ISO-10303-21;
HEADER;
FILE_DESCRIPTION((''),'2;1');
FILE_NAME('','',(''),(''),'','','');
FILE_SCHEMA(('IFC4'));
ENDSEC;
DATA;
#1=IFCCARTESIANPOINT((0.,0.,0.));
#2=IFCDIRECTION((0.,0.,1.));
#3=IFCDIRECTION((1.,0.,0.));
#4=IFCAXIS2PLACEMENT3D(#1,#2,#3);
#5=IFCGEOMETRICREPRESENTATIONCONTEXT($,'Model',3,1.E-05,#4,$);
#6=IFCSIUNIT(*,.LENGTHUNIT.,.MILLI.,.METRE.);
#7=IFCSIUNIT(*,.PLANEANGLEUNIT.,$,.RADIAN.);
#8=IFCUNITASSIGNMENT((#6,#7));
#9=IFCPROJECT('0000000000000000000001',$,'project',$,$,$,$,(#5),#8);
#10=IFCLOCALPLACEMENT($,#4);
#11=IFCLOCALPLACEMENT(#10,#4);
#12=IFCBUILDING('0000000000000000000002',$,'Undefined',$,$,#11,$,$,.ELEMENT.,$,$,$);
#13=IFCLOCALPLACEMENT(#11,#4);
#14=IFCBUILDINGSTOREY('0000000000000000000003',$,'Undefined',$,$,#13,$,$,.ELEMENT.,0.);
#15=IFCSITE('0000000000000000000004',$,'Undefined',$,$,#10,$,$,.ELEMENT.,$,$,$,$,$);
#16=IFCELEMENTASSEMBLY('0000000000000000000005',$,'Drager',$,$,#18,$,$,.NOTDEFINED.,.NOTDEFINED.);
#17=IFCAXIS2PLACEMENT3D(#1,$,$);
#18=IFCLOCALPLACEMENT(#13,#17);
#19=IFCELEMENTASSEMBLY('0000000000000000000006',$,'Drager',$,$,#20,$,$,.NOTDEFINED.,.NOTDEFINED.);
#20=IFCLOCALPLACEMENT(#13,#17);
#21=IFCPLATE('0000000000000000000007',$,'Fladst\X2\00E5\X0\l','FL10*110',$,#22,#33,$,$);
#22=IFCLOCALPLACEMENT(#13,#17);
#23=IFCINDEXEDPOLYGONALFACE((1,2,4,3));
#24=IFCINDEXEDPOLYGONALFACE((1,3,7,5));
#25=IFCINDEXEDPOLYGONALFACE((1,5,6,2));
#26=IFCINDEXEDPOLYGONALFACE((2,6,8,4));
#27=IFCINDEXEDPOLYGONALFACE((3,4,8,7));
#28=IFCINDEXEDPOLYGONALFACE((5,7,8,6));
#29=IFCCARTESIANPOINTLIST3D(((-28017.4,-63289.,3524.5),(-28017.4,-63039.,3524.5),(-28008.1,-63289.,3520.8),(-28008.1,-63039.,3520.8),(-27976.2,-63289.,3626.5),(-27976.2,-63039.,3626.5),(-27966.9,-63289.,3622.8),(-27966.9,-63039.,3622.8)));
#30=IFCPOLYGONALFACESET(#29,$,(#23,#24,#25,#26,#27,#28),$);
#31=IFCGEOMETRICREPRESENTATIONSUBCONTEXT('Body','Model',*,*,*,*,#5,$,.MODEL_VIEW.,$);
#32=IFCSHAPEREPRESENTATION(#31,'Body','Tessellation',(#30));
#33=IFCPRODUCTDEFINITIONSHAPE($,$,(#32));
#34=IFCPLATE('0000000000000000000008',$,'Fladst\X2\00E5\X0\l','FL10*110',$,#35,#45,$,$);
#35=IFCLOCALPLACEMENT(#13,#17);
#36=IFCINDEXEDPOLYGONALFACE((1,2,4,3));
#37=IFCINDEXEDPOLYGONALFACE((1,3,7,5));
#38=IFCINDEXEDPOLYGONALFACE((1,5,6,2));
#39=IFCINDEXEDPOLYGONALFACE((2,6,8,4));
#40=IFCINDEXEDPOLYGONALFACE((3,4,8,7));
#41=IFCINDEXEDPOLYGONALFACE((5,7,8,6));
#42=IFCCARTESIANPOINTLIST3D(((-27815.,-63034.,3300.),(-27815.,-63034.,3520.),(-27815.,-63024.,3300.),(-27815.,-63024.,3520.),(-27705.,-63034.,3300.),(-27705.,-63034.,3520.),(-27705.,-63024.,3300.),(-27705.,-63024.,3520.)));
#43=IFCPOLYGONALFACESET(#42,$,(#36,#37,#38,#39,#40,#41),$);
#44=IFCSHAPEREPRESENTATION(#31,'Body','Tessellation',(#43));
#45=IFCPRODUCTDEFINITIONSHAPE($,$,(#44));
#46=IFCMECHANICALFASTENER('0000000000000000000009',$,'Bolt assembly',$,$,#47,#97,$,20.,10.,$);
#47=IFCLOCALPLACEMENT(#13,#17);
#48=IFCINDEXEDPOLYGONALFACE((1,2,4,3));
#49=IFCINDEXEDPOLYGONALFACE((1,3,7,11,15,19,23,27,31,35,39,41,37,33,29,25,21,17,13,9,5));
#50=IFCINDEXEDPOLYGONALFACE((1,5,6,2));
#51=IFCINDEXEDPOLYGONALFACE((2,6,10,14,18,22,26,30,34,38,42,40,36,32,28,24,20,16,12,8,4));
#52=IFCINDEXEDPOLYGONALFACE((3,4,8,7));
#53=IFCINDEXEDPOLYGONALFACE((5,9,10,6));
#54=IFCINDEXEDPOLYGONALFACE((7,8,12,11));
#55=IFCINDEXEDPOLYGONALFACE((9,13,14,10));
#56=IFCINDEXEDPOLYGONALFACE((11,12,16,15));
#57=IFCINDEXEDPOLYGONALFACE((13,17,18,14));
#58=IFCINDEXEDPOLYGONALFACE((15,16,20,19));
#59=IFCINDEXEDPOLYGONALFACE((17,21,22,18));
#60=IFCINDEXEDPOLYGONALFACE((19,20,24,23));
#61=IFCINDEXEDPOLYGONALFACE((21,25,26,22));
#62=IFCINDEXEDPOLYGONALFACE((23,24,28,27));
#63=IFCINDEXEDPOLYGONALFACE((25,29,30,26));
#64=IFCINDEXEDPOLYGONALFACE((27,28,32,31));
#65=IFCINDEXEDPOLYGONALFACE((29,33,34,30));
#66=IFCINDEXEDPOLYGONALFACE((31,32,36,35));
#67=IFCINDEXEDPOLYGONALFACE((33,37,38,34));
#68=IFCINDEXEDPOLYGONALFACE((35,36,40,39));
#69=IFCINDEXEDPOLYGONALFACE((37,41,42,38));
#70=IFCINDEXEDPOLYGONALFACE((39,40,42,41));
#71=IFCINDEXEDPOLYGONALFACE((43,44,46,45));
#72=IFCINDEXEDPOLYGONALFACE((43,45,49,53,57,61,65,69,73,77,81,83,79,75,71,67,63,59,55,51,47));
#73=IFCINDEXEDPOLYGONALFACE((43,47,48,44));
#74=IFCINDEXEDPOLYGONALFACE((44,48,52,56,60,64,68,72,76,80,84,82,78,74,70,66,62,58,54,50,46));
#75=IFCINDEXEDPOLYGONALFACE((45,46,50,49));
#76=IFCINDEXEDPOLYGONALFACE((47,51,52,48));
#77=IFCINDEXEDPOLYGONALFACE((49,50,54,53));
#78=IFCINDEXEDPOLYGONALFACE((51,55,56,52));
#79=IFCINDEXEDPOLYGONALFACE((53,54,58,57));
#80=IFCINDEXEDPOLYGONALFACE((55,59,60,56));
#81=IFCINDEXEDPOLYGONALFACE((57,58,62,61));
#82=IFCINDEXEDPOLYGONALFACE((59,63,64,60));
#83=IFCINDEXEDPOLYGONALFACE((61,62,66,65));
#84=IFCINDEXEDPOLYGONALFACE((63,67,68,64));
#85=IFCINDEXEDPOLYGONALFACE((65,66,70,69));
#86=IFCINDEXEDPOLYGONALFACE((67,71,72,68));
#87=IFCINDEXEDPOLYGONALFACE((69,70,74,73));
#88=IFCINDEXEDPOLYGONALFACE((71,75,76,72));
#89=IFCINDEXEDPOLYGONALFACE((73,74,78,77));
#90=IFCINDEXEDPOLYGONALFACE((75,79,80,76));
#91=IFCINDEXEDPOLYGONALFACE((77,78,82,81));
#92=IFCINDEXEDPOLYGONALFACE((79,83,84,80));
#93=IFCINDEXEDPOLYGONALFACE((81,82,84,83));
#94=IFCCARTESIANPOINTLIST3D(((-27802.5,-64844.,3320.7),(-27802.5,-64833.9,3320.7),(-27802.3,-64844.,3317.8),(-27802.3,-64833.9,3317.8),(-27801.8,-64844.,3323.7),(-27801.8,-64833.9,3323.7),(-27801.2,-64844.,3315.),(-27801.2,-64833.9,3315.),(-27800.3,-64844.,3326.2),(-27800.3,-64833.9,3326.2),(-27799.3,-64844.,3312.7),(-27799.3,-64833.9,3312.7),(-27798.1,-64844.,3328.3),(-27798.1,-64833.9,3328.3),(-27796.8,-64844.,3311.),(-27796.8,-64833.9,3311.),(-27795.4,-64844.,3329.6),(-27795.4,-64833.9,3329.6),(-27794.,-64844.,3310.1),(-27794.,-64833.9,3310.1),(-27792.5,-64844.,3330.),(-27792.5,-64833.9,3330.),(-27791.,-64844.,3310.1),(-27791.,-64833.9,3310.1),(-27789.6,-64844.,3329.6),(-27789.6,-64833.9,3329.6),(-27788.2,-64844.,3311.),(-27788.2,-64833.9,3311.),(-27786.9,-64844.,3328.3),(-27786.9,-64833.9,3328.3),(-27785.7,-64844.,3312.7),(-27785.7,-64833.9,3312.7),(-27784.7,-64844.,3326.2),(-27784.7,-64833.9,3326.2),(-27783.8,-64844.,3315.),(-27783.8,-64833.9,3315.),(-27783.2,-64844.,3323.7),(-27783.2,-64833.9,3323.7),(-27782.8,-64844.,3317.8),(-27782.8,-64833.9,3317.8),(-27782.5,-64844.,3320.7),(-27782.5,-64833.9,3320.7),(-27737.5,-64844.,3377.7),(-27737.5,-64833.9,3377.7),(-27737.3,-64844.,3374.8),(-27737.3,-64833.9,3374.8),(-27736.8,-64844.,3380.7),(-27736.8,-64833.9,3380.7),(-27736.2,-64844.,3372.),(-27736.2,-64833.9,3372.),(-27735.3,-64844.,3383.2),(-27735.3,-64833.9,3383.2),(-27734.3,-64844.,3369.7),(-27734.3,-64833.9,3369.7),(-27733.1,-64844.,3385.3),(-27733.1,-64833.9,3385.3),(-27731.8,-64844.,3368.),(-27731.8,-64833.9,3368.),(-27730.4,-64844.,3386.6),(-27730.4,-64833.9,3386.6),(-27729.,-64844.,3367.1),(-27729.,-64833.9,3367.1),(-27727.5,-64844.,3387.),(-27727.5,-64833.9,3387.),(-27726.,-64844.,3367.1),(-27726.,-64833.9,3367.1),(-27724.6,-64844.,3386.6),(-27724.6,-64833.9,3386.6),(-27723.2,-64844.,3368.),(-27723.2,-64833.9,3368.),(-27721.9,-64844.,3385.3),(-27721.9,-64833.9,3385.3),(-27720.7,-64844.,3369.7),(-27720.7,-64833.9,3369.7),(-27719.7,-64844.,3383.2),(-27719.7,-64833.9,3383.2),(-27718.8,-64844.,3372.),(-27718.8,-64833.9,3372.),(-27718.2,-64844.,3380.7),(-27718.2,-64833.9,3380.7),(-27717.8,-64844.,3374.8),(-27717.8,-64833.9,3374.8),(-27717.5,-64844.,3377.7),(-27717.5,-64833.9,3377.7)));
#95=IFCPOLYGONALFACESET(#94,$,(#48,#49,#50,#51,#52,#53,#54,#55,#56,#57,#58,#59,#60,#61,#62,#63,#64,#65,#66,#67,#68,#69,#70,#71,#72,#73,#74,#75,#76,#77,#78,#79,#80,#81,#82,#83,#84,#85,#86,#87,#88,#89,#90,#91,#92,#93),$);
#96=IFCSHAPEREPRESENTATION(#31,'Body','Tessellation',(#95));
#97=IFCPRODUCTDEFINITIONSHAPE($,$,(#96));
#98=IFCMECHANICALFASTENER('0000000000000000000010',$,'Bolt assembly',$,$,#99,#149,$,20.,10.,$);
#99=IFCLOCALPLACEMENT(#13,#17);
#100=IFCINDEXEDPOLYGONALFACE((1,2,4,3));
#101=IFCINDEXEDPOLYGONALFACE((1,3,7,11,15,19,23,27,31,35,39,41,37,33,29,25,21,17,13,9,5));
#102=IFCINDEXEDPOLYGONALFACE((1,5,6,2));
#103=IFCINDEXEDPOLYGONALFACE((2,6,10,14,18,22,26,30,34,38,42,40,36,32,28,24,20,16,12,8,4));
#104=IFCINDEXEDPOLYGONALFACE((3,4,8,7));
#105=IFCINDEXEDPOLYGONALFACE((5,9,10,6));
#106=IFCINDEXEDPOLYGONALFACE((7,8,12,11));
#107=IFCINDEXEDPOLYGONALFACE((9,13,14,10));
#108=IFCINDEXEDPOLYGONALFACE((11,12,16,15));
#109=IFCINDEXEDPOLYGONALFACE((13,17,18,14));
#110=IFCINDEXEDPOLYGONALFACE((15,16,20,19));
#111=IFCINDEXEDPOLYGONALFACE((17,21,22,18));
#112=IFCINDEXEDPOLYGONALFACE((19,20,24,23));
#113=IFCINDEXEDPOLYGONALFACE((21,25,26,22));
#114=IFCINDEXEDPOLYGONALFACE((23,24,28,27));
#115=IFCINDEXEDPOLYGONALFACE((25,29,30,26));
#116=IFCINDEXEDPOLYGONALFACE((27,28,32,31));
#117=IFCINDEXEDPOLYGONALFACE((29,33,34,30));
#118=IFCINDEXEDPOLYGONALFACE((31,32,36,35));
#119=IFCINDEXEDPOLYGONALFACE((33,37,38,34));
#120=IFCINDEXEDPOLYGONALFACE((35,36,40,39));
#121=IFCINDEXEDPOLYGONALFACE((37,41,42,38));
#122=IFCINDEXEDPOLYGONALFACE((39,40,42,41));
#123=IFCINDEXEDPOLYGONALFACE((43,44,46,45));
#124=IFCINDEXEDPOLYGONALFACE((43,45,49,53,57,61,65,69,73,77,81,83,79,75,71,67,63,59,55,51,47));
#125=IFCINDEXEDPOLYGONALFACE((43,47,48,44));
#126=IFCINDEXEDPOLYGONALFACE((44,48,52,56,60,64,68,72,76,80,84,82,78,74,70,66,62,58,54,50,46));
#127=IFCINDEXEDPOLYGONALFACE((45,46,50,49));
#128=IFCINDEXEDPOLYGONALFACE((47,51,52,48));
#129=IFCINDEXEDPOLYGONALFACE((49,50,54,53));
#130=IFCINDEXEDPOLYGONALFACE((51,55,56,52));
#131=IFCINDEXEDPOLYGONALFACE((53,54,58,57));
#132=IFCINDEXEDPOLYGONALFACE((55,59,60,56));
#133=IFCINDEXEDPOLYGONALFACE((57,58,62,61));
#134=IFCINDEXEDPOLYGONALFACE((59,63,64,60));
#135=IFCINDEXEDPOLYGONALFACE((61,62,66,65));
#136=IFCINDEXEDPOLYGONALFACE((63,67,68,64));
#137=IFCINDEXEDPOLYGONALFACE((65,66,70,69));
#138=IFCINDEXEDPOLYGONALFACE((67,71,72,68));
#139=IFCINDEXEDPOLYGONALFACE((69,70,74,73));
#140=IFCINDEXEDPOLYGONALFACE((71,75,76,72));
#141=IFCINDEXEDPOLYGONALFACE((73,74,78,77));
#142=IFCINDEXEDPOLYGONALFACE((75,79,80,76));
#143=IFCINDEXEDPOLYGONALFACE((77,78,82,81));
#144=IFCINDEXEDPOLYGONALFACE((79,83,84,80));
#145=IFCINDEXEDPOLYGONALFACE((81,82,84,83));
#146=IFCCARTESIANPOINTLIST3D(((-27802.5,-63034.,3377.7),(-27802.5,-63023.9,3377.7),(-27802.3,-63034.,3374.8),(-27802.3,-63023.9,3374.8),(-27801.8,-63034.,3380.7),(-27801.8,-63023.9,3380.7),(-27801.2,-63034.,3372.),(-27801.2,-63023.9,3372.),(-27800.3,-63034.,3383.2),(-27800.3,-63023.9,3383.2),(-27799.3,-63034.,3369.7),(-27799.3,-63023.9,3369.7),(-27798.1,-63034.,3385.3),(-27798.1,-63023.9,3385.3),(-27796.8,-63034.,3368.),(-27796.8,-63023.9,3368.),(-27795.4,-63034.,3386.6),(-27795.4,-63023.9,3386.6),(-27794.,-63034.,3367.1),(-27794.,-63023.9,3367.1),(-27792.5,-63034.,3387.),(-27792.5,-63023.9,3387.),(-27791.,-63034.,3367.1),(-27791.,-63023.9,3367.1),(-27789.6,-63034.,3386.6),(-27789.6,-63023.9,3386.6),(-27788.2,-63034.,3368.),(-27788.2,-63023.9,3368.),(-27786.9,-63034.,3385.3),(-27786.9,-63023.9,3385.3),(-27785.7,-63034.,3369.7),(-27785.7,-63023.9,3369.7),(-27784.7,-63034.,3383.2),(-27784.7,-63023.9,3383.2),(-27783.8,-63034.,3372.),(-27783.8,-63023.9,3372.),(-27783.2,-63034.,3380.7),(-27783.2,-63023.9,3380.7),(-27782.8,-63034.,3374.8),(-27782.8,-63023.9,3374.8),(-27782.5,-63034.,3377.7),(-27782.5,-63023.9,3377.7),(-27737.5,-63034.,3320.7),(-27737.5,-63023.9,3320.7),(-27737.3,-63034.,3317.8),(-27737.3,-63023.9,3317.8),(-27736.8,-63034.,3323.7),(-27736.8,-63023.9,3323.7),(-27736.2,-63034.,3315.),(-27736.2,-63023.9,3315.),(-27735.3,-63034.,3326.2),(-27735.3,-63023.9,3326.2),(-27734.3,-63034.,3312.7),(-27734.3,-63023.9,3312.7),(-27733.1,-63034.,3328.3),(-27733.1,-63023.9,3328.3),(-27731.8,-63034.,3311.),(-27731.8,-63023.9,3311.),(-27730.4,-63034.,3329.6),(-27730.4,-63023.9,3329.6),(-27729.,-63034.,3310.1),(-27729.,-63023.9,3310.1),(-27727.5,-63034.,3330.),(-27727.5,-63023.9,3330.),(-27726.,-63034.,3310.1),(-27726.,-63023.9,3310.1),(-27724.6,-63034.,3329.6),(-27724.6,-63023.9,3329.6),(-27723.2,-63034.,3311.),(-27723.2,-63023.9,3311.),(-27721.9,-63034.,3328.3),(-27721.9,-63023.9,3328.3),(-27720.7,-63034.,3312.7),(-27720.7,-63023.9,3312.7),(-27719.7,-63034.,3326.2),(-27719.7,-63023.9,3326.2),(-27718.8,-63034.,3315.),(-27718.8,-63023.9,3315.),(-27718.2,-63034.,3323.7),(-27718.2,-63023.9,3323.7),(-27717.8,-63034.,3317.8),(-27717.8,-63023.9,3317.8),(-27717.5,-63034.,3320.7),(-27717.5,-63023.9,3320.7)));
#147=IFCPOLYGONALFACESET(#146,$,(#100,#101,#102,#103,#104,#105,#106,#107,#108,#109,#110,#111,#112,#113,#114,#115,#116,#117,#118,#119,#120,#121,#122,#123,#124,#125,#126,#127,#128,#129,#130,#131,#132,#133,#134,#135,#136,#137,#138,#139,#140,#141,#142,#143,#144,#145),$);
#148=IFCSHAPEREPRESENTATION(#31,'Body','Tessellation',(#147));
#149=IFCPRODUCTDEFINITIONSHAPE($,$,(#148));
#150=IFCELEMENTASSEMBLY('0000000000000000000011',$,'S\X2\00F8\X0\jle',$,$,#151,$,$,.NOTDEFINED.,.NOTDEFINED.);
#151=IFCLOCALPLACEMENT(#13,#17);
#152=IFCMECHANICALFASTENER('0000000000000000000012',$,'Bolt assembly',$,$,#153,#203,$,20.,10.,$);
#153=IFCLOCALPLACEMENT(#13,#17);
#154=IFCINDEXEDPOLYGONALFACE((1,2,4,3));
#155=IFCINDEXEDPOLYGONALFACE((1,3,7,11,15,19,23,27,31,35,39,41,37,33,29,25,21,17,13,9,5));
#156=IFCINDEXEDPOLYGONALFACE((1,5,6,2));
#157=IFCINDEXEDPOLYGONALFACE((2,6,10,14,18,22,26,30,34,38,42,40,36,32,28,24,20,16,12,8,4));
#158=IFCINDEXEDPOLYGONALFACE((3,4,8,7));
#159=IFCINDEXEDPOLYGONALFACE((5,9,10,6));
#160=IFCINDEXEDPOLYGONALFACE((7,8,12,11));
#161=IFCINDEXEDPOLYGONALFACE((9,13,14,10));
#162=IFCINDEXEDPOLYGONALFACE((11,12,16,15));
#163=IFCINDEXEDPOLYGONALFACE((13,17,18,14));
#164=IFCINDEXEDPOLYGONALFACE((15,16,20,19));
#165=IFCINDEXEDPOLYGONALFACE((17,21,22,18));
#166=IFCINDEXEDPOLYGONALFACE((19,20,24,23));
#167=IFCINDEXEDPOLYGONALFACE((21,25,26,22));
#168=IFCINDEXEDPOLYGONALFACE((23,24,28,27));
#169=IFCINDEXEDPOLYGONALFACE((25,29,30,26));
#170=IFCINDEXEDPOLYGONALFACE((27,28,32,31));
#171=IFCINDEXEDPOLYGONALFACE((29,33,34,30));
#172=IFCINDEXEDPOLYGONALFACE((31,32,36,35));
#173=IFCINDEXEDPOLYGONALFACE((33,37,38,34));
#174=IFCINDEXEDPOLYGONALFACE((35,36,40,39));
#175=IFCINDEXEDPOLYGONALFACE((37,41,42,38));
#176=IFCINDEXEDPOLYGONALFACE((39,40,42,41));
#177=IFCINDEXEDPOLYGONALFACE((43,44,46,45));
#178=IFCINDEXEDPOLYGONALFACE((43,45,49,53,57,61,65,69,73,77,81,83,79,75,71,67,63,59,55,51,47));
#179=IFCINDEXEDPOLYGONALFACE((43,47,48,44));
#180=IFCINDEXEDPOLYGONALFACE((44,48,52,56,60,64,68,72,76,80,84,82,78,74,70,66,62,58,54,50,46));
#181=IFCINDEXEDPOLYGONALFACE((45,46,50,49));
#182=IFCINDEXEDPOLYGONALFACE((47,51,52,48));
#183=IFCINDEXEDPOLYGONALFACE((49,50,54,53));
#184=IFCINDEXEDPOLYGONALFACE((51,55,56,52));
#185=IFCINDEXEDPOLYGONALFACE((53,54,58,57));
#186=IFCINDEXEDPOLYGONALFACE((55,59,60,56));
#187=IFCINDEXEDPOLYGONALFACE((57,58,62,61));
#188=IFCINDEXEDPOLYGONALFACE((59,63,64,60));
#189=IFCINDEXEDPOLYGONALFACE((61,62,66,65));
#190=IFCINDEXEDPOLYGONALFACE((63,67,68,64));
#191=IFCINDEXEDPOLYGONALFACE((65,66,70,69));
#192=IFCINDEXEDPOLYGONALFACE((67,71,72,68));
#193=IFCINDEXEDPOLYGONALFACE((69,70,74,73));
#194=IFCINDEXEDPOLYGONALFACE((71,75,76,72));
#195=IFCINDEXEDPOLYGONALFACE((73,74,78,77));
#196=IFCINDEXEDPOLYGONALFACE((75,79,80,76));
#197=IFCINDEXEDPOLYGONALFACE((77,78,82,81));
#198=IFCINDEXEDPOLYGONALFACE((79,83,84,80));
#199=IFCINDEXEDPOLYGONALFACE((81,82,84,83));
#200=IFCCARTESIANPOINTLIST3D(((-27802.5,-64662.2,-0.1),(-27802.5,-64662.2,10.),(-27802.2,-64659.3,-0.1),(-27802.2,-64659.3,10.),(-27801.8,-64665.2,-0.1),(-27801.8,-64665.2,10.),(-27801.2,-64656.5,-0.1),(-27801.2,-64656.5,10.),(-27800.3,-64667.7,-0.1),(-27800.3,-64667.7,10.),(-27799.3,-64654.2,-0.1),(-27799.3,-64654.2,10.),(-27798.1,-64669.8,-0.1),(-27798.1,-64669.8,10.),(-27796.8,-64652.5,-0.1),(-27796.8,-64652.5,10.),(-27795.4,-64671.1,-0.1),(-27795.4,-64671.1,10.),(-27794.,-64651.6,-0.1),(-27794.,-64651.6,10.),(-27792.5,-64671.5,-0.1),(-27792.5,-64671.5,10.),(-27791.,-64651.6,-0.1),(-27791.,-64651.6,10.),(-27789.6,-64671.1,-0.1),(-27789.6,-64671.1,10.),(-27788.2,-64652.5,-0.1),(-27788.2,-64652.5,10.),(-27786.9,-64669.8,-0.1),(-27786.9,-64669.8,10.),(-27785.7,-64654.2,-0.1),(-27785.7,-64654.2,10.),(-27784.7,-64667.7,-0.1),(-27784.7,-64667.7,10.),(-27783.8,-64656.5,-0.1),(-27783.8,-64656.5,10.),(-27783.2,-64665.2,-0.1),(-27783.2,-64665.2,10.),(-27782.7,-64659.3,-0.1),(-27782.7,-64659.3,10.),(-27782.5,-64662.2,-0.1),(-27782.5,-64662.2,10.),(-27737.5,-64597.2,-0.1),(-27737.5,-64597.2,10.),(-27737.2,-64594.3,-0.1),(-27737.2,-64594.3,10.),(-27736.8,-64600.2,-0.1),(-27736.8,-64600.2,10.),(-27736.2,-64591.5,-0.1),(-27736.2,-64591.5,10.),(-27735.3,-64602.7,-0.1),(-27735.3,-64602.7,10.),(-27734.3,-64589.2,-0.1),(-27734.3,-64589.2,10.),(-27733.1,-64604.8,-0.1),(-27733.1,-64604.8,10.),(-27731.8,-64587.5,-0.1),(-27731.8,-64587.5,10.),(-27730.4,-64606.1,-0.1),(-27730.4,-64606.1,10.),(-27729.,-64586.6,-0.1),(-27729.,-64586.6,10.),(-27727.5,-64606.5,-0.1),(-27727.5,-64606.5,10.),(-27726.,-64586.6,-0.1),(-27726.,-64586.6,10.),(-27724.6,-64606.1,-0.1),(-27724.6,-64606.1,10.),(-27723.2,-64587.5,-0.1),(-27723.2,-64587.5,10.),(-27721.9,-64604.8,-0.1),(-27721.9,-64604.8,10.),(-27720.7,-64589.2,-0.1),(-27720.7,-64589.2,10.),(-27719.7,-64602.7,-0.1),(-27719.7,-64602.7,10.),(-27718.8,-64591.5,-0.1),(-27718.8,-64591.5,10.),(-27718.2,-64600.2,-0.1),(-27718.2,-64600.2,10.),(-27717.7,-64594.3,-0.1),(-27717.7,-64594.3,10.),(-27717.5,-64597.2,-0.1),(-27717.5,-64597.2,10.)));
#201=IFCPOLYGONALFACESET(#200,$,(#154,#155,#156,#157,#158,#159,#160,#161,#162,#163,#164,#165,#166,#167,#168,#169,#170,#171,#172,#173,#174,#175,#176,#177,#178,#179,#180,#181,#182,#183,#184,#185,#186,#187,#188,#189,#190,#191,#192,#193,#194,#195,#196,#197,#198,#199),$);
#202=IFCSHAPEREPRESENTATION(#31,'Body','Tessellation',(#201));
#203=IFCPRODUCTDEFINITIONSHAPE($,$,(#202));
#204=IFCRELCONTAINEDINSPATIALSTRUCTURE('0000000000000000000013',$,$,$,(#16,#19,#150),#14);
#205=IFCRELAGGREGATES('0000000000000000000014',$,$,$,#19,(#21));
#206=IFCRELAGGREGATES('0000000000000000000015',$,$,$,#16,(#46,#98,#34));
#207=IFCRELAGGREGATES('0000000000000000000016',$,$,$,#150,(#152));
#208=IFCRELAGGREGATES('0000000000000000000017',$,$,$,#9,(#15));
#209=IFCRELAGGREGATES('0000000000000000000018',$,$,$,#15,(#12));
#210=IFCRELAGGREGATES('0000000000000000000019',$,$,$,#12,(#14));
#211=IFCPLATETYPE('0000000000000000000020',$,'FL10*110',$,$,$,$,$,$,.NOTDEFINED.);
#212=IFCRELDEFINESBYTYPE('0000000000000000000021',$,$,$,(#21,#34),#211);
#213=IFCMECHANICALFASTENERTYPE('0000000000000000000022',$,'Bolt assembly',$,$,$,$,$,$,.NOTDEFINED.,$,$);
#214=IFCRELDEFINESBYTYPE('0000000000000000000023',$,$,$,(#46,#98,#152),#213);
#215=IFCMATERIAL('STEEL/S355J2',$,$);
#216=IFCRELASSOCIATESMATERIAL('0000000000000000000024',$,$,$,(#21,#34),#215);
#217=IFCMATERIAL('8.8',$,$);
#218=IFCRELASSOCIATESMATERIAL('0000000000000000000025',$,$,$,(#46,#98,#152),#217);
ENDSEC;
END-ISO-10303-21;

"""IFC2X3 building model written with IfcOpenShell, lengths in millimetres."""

from ifc_helpers import new_model, si_unit, frame, origin_with_axes, origin_2d_with_axis, place, context, subcontext, project, spatial, polyline, circle, outline, extrude, source, transform, mapped, material, type_object, element, aggregate, save


model = new_model("IFC2X3")

# Units and contexts
model_context = context("Model", 3, precision=1e-05, world=origin_with_axes())
body_context = subcontext(model_context, "Body", "Model", "MODEL_VIEW")
ifc_project = project(units=[si_unit("LENGTHUNIT", "METRE", prefix="MILLI"), si_unit("PLANEANGLEUNIT", "RADIAN")], contexts=[model_context])

# Site, building, storey
site_placement = place(None, origin_with_axes())
site = spatial("IfcSite", under=ifc_project, at=site_placement, Name="Undefined", CompositionType="ELEMENT")
building_placement = place(site_placement, origin_with_axes())
building = spatial("IfcBuilding", under=site, at=building_placement, Name="Undefined", CompositionType="ELEMENT")
storey_placement = place(building_placement, origin_with_axes())
storey = spatial("IfcBuildingStorey", under=building, at=storey_placement, Name="Undefined", CompositionType="ELEMENT", Elevation=0.0)

# Shared definitions
ifc_material_1 = material(Name="STEEL/S355J2")

# Element assembly
assembly_1_placement = place(storey_placement, origin_with_axes())
assembly_1 = element("IfcElementAssembly", 1, at=assembly_1_placement, inside=storey, Name="Drager", AssemblyPlace="NOTDEFINED", PredefinedType="NOTDEFINED")

# Shared definitions
plate_type_1 = type_object("IfcPlateType", Name="FL10*110", PredefinedType="NOTDEFINED")

# Element assembly, plate
assembly_2_placement = place(storey_placement, origin_with_axes())
assembly_2 = element("IfcElementAssembly", 2, at=assembly_2_placement, inside=storey, Name="Drager", AssemblyPlace="NOTDEFINED", PredefinedType="NOTDEFINED")
plate_1_placement = place(assembly_2_placement, frame((-27992.2, -63039.0, 3573.6), z_axis=(0.927183, 0.0, -0.374609), x_axis=(0.0, -1.0, 0.0)))
plate_1 = element("IfcPlate", 3, at=plate_1_placement, type_object=plate_type_1, material=ifc_material_1, Name="Fladstål", Description="FL10*110", context=body_context, shape_type="SweptSolid", body=[
    extrude(outline(polyline([(0.0, -55.0), (0.0, 55.0), (250.0, 55.0), (250.0, -55.0), (0.0, -55.0)])), frame((0.0, 0.0, -5.0), z_axis=(0.0, 0.0, 1.0), x_axis=(1.0, 0.0, 0.0)), (0.0, 0.0, 1.0), 10.0),
])
aggregate(assembly_2, [plate_1])

# Plate
plate_2_placement = place(assembly_1_placement, frame((-27760.0, -63029.0, 3300.0), z_axis=(0.0, -1.0, 0.0), x_axis=(0.0, 0.0, 1.0)))
plate_2 = element("IfcPlate", 4, at=plate_2_placement, type_object=plate_type_1, material=ifc_material_1, Name="Fladstål", Description="FL10*110", context=body_context, shape_type="SweptSolid", body=[
    extrude(outline(polyline([(0.0, -55.0), (0.0, 55.0), (220.0, 55.0), (220.0, -55.0), (0.0, -55.0)])), frame((0.0, 0.0, -5.0), z_axis=(0.0, 0.0, 1.0), x_axis=(1.0, 0.0, 0.0)), (0.0, 0.0, 1.0), 10.0),
])

# Mechanical fasteners
ifc_material_2 = material(Name="8.8")
mechanical_fastener_type = type_object("IfcMechanicalFastenerType", Name="Bolt assembly")
shared_shape_1 = source(origin_with_axes(), body_context, "Body", "SweptSolid", [
    extrude(circle(Radius=10.0, at=origin_2d_with_axis()), frame((0.0, 0.0, 0.0), z_axis=(0.0, 1.0, 0.0), x_axis=(1.0, 0.0, 0.0)), (0.0, 0.0, 1.0), 10.1),
])
mechanical_fastener_1_placement = place(assembly_1_placement, frame((-27760.0, -64844.0, 3320.0), z_axis=(-1.0, 0.0, 0.0), x_axis=(0.0, 0.0, 1.0)))
mechanical_fastener_1 = element("IfcMechanicalFastener", 5, at=mechanical_fastener_1_placement, type_object=mechanical_fastener_type, material=ifc_material_2, Name="Bolt assembly", NominalDiameter=20.0, NominalLength=10.0, context=body_context, shape_type="MappedRepresentation", body=[
    mapped(shared_shape_1, transform((57.0, 0.0, -32.5))),
    mapped(shared_shape_1, transform((0.0, 0.0, 32.5))),
])
mechanical_fastener_2_placement = place(assembly_1_placement, frame((-27760.0, -63034.0, 3320.0), z_axis=(-1.0, 0.0, 0.0), x_axis=(0.0, 0.0, 1.0)))
mechanical_fastener_2 = element("IfcMechanicalFastener", 6, at=mechanical_fastener_2_placement, type_object=mechanical_fastener_type, material=ifc_material_2, Name="Bolt assembly", NominalDiameter=20.0, NominalLength=10.0, context=body_context, shape_type="MappedRepresentation", body=[
    mapped(shared_shape_1, transform((0.0, 0.0, -32.5))),
    mapped(shared_shape_1, transform((57.0, 0.0, 32.5))),
])
aggregate(assembly_1, [mechanical_fastener_1, mechanical_fastener_2, plate_2])

# Element assembly, mechanical fastener
assembly_3_placement = place(storey_placement, origin_with_axes())
assembly_3 = element("IfcElementAssembly", 7, at=assembly_3_placement, inside=storey, Name="Søjle", AssemblyPlace="NOTDEFINED", PredefinedType="NOTDEFINED")
mechanical_fastener_3_placement = place(assembly_3_placement, frame((-27760.0, -64596.5, 10.0), z_axis=(1.0, 0.0, 0.0), x_axis=(0.0, -1.0, 0.0)))
mechanical_fastener_3 = element("IfcMechanicalFastener", 8, at=mechanical_fastener_3_placement, type_object=mechanical_fastener_type, material=ifc_material_2, Name="Bolt assembly", NominalDiameter=20.0, NominalLength=10.0, context=body_context, shape_type="MappedRepresentation", body=[
    mapped(shared_shape_1, transform((65.0, 0.0, -32.5))),
    mapped(shared_shape_1, transform((0.0, 0.0, 32.5))),
])

aggregate(assembly_3, [mechanical_fastener_3])

save(model, "model.ifc")
